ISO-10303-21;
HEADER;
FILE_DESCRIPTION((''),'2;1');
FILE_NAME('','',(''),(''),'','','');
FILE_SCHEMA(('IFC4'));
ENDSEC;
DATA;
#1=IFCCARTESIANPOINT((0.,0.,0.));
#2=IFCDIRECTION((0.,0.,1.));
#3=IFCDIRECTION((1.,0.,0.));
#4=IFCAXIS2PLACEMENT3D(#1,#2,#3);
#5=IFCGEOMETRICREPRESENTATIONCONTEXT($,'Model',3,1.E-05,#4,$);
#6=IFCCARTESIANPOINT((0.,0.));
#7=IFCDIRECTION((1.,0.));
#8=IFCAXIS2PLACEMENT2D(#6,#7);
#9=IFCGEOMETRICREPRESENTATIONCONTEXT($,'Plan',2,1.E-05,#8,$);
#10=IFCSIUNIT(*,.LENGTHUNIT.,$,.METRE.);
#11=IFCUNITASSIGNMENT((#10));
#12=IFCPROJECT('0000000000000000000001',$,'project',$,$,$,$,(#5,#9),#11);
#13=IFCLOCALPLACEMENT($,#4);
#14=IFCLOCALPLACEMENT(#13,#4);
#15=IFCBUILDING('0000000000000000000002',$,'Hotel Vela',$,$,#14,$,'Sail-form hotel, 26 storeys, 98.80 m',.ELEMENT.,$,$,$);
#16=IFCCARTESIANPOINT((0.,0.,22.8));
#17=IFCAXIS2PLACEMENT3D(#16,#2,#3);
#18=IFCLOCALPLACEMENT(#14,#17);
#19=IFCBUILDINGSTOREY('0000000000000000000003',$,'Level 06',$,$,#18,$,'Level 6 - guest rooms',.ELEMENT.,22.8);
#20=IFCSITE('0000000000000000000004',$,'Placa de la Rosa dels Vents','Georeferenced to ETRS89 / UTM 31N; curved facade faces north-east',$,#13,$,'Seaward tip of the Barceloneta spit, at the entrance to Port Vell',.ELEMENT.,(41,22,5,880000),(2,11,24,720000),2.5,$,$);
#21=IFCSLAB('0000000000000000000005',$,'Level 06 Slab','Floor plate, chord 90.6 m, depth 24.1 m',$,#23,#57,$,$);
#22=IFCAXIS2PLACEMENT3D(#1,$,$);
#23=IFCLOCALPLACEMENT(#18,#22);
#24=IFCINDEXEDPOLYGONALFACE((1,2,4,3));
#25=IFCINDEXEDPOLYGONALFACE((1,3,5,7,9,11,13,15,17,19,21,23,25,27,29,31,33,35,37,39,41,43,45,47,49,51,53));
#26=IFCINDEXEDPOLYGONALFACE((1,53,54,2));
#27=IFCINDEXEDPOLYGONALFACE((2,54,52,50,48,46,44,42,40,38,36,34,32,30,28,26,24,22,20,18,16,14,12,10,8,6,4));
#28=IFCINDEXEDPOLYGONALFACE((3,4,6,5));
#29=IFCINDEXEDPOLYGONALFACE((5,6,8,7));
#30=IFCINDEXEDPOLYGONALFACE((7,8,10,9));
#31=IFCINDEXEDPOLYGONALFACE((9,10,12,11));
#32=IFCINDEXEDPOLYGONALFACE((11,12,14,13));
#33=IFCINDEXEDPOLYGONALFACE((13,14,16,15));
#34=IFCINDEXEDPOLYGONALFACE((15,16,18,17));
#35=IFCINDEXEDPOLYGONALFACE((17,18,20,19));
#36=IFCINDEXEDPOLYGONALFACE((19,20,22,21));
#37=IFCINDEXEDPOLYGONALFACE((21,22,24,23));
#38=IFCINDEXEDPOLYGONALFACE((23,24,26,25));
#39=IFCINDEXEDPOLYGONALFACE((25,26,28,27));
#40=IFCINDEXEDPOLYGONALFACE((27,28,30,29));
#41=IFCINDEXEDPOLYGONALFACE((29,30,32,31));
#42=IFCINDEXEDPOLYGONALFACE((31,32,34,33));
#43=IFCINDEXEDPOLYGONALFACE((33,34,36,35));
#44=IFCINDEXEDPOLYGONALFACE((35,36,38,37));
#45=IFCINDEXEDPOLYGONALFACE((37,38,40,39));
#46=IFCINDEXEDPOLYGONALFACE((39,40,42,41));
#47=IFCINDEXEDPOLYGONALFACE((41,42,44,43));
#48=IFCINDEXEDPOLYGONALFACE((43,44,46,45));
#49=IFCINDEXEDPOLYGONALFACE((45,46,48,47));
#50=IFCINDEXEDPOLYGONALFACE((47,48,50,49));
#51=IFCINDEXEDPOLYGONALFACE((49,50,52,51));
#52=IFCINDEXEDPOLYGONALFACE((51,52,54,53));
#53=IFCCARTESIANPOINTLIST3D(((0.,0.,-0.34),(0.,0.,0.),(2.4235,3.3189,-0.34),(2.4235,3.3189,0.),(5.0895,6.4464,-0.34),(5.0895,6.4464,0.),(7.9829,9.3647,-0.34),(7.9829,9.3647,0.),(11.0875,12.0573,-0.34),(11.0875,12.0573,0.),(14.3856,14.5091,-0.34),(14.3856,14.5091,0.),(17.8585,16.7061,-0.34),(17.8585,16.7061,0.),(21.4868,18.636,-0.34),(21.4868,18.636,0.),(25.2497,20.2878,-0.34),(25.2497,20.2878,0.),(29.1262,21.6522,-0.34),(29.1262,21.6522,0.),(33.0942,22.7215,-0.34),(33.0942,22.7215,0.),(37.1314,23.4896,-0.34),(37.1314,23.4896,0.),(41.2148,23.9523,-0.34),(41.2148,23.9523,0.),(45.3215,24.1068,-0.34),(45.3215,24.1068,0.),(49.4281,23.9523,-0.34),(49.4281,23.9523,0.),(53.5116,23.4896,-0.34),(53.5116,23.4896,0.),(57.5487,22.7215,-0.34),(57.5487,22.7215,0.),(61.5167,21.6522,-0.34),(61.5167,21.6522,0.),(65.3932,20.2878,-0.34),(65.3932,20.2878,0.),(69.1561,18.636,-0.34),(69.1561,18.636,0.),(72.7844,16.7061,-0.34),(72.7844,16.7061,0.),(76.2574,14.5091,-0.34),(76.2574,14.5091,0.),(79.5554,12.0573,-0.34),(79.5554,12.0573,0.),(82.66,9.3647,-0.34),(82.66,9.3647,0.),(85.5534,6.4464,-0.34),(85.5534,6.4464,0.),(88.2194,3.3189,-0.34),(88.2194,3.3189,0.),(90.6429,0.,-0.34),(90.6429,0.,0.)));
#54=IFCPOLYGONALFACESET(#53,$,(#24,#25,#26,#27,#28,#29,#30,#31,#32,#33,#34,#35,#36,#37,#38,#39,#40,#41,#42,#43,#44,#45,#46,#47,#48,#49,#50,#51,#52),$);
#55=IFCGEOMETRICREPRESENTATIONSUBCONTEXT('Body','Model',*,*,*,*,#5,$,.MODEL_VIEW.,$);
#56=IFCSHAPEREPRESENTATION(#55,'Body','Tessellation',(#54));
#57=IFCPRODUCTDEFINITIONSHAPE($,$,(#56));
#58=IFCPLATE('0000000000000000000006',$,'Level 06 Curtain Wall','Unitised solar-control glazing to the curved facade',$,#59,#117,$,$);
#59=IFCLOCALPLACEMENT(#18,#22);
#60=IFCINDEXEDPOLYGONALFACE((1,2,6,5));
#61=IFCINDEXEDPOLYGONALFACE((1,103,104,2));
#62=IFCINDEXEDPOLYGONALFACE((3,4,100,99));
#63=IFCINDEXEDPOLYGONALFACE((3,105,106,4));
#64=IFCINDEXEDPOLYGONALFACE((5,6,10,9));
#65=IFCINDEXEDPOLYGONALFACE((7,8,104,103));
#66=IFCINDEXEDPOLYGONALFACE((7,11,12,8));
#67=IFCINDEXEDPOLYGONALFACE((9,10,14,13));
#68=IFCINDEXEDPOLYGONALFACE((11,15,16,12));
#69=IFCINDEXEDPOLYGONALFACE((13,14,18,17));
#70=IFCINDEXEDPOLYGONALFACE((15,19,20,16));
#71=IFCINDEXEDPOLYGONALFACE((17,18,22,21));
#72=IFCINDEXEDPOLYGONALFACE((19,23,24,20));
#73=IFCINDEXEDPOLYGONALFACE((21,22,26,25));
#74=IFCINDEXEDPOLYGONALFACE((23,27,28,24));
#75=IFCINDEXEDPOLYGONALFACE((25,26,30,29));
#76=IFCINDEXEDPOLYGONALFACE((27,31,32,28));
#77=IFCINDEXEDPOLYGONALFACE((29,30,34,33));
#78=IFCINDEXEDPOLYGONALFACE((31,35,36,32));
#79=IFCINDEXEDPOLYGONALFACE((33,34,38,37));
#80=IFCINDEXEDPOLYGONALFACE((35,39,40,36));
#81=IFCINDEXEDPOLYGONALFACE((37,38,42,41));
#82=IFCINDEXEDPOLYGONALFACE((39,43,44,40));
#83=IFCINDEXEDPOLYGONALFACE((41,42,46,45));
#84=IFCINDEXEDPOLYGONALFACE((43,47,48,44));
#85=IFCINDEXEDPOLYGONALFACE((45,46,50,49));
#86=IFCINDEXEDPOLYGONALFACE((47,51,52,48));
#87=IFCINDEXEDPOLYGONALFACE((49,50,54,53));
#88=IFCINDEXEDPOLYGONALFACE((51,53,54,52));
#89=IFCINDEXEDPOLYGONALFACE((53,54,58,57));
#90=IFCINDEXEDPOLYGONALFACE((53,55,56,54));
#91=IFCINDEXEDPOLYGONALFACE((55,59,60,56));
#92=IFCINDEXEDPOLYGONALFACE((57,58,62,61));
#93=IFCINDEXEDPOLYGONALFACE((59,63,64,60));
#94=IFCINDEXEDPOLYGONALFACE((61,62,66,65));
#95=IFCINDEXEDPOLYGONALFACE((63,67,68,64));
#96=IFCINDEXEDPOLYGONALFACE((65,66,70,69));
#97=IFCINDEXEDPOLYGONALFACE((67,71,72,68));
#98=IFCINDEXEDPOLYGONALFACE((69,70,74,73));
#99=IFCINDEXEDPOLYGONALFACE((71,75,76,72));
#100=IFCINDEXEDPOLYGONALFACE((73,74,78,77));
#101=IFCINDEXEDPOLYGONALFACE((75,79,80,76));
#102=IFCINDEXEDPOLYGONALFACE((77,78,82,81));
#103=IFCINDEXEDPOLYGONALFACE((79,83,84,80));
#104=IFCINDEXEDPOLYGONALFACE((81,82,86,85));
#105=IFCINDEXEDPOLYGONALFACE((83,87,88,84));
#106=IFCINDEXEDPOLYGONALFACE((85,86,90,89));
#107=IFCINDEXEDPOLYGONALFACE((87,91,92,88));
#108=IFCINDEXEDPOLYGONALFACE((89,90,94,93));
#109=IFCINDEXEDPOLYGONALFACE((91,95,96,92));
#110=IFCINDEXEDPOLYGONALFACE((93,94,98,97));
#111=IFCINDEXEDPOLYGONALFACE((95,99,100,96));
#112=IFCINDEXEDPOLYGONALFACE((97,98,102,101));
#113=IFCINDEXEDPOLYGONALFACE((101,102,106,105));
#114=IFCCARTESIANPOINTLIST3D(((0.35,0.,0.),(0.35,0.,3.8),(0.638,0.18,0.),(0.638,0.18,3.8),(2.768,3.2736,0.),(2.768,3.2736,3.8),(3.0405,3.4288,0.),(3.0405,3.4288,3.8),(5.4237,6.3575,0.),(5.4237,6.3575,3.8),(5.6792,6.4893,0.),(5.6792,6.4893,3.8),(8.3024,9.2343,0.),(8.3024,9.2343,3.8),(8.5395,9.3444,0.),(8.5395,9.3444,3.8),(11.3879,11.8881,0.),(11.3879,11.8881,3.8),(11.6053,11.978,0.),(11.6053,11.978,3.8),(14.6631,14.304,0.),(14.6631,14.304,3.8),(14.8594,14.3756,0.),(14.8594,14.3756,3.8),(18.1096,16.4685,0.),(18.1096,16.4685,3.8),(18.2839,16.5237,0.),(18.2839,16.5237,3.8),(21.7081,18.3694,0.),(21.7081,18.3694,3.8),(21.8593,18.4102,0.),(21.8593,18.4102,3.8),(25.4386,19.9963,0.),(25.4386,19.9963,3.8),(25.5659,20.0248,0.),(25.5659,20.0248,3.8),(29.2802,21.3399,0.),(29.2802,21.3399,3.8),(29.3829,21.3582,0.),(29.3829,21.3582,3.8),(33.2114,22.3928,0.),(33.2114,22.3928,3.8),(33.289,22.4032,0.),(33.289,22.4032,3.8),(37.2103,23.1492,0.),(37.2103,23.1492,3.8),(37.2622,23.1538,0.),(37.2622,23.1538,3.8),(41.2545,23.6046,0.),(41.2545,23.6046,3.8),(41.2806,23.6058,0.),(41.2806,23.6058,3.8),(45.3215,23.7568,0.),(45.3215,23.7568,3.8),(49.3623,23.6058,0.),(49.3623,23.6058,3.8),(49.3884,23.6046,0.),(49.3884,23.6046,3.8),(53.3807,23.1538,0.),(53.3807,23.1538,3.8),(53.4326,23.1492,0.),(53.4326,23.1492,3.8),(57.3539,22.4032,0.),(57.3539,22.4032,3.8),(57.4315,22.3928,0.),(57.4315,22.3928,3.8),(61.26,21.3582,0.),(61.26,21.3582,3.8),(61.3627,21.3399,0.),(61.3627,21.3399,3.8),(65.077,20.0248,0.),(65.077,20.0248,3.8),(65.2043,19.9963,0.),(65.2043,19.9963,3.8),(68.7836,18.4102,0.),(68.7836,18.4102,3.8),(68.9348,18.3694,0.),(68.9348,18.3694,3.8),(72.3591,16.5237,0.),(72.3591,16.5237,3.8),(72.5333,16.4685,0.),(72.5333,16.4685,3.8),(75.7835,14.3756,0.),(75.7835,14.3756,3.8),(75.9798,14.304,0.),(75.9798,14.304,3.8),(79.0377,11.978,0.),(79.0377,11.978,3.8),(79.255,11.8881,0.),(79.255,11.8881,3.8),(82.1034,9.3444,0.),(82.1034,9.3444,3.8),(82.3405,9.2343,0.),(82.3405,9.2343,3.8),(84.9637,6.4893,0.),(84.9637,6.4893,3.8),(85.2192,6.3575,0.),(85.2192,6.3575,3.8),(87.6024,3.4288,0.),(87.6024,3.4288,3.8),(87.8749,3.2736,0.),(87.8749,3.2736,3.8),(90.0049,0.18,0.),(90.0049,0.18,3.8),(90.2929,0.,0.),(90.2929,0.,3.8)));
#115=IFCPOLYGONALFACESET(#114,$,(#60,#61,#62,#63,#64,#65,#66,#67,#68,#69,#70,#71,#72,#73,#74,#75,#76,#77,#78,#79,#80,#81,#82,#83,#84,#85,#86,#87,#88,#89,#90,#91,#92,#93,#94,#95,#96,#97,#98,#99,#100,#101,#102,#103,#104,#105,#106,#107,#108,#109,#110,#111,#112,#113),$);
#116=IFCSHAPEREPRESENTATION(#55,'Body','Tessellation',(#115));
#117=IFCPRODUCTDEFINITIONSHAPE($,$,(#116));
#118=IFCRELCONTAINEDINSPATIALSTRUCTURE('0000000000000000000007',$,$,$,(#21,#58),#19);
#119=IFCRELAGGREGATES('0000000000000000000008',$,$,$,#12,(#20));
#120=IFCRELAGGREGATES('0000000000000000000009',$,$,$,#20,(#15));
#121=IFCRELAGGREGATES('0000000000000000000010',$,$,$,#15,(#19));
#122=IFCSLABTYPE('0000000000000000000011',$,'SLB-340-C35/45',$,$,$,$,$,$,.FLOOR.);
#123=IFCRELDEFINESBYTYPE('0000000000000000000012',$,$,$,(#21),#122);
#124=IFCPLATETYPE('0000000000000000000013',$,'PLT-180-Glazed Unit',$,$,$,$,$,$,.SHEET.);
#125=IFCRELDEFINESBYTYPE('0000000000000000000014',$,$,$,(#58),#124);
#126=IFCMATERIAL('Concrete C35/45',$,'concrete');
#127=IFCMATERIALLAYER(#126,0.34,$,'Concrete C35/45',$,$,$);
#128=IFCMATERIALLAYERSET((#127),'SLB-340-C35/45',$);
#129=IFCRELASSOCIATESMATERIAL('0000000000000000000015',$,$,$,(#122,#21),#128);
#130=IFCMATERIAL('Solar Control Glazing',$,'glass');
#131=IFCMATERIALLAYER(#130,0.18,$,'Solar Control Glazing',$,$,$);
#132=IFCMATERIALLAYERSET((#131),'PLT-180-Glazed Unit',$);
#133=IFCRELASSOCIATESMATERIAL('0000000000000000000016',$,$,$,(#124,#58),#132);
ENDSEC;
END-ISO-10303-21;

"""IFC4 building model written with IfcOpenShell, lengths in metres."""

from ifc_helpers import new_model, si_unit, frame, origin_with_axes, origin_2d_with_axis, place, context, subcontext, project, spatial, line, indexed_curve, outline, extrude, material, layer, layer_set, layer_usage, type_object, element, save


model = new_model("IFC4")

# Units and contexts
model_context = context("Model", 3, precision=1e-05, world=origin_with_axes())
plan_context = context("Plan", 2, precision=1e-05, world=origin_2d_with_axis())
body_context = subcontext(model_context, "Body", "Model", "MODEL_VIEW")
ifc_project = project(units=[si_unit("LENGTHUNIT", "METRE")], contexts=[model_context, plan_context])

# Site, building, storey
site_placement = place(None, origin_with_axes())
site = spatial("IfcSite", under=ifc_project, at=site_placement, Name="Placa de la Rosa dels Vents", Description="Georeferenced to ETRS89 / UTM 31N; curved facade faces north-east", LongName="Seaward tip of the Barceloneta spit, at the entrance to Port Vell", CompositionType="ELEMENT", RefLatitude=(41, 22, 5, 880000), RefLongitude=(2, 11, 24, 720000), RefElevation=2.5)
building_placement = place(site_placement, origin_with_axes())
building = spatial("IfcBuilding", under=site, at=building_placement, Name="Hotel Vela", LongName="Sail-form hotel, 26 storeys, 98.80 m", CompositionType="ELEMENT")
storey_placement = place(building_placement, frame((0.0, 0.0, 22.8), z_axis=(0.0, 0.0, 1.0), x_axis=(1.0, 0.0, 0.0)))
storey = spatial("IfcBuildingStorey", under=building, at=storey_placement, Name="Level 06", LongName="Level 6 - guest rooms", CompositionType="ELEMENT", Elevation=22.8)

# Slab
ifc_material_1 = material(Name="Concrete C35/45", Category="concrete")
ifc_layer_1 = layer(ifc_material_1, 0.34, Name="Concrete C35/45")
ifc_layer_set_1 = layer_set([ifc_layer_1], Name="SLB-340-C35/45")
ifc_layer_usage_1 = layer_usage(ifc_layer_set_1, "AXIS3", "POSITIVE", 0.0)
slab_type = type_object("IfcSlabType", Name="SLB-340-C35/45", PredefinedType="FLOOR", material=ifc_layer_set_1)
slab_placement = place(storey_placement, frame((0.0, 0.0, -0.34), z_axis=(0.0, 0.0, 1.0), x_axis=(1.0, 0.0, 0.0)))
element("IfcSlab", 1, at=slab_placement, inside=storey, type_object=slab_type, material=ifc_layer_usage_1, Name="Level 06 Slab", Description="Floor plate, chord 90.6 m, depth 24.1 m", context=body_context, shape_type="SweptSolid", body=[
    extrude(outline(indexed_curve([(0.0, 0.0), (90.6429, 0.0), (88.2194, 3.3189), (85.5534, 6.4464), (82.66, 9.3647), (79.5554, 12.0573), (76.2574, 14.5091), (72.7844, 16.7061), (69.1561, 18.636), (65.3932, 20.2878), (61.5167, 21.6522), (57.5487, 22.7215), (53.5116, 23.4896), (49.4281, 23.9523), (45.3215, 24.1068), (41.2148, 23.9523), (37.1314, 23.4896), (33.0942, 22.7215), (29.1262, 21.6522), (25.2497, 20.2878), (21.4868, 18.636), (17.8585, 16.7061), (14.3856, 14.5091), (11.0875, 12.0573), (7.9829, 9.3647), (5.0895, 6.4464), (2.4235, 3.3189)], segments=[line(1, 2, 3, 4, 5, 6, 7, 8, 9, 10, 11, 12, 13, 14, 15, 16, 17, 18, 19, 20, 21, 22, 23, 24, 25, 26, 27, 1)])), origin_with_axes(), (0.0, 0.0, 1.0), 0.34),
])

# Plate
ifc_material_2 = material(Name="Solar Control Glazing", Category="glass")
ifc_layer_2 = layer(ifc_material_2, 0.18, Name="Solar Control Glazing")
ifc_layer_set_2 = layer_set([ifc_layer_2], Name="PLT-180-Glazed Unit")
ifc_layer_usage_2 = layer_usage(ifc_layer_set_2, "AXIS2", "POSITIVE", 0.0)
plate_type_1 = type_object("IfcPlateType", Name="PLT-180-Glazed Unit", PredefinedType="SHEET", material=ifc_layer_set_2)
plate_1_placement = place(storey_placement, frame((0.35, 0.0, 0.0), z_axis=(0.0, 0.0, 1.0), x_axis=(1.0, 0.0, 0.0)))
element("IfcPlate", 2, at=plate_1_placement, inside=storey, type_object=plate_type_1, material=ifc_layer_usage_2, Name="Level 06 Curtain Wall", Description="Unitised solar-control glazing to the curved facade", context=body_context, shape_type="SweptSolid", body=[
    extrude(outline(indexed_curve([(89.9429, 0.0), (87.5249, 3.2736), (84.8692, 6.3575), (81.9905, 9.2343), (78.905, 11.8881), (75.6298, 14.304), (72.1833, 16.4685), (68.5848, 18.3694), (64.8543, 19.9963), (61.0127, 21.3399), (57.0815, 22.3928), (53.0826, 23.1492), (49.0384, 23.6046), (44.9715, 23.7568), (40.9045, 23.6046), (36.8603, 23.1492), (32.8614, 22.3928), (28.9302, 21.3399), (25.0886, 19.9963), (21.3581, 18.3694), (17.7596, 16.4685), (14.3131, 14.304), (11.0379, 11.8881), (7.9524, 9.2343), (5.0737, 6.3575), (2.418, 3.2736), (0.0, 0.0), (89.6549, 0.18), (2.6905, 3.4288), (5.3292, 6.4893), (8.1895, 9.3444), (11.2553, 11.978), (14.5094, 14.3756), (17.9339, 16.5237), (21.5093, 18.4102), (25.2159, 20.0248), (29.0329, 21.3582), (32.939, 22.4032), (36.9122, 23.1538), (40.9306, 23.6058), (44.9715, 23.7568), (49.0123, 23.6058), (53.0307, 23.1538), (57.0039, 22.4032), (60.91, 21.3582), (64.727, 20.0248), (68.4336, 18.4102), (72.0091, 16.5237), (75.4335, 14.3756), (78.6877, 11.978), (81.7534, 9.3444), (84.6137, 6.4893), (87.2524, 3.4288), (0.288, 0.18)], segments=[line(1, 2, 3, 4, 5, 6, 7, 8, 9, 10, 11, 12, 13, 14, 15, 16, 17, 18, 19, 20, 21, 22, 23, 24, 25, 26, 27, 28, 29, 30, 31, 32, 33, 34, 35, 36, 37, 38, 39, 40, 41, 42, 43, 44, 45, 46, 47, 48, 49, 50, 51, 52, 53, 54, 1)])), origin_with_axes(), (0.0, 0.0, 1.0), 3.8),
])

save(model, "model.ifc")
